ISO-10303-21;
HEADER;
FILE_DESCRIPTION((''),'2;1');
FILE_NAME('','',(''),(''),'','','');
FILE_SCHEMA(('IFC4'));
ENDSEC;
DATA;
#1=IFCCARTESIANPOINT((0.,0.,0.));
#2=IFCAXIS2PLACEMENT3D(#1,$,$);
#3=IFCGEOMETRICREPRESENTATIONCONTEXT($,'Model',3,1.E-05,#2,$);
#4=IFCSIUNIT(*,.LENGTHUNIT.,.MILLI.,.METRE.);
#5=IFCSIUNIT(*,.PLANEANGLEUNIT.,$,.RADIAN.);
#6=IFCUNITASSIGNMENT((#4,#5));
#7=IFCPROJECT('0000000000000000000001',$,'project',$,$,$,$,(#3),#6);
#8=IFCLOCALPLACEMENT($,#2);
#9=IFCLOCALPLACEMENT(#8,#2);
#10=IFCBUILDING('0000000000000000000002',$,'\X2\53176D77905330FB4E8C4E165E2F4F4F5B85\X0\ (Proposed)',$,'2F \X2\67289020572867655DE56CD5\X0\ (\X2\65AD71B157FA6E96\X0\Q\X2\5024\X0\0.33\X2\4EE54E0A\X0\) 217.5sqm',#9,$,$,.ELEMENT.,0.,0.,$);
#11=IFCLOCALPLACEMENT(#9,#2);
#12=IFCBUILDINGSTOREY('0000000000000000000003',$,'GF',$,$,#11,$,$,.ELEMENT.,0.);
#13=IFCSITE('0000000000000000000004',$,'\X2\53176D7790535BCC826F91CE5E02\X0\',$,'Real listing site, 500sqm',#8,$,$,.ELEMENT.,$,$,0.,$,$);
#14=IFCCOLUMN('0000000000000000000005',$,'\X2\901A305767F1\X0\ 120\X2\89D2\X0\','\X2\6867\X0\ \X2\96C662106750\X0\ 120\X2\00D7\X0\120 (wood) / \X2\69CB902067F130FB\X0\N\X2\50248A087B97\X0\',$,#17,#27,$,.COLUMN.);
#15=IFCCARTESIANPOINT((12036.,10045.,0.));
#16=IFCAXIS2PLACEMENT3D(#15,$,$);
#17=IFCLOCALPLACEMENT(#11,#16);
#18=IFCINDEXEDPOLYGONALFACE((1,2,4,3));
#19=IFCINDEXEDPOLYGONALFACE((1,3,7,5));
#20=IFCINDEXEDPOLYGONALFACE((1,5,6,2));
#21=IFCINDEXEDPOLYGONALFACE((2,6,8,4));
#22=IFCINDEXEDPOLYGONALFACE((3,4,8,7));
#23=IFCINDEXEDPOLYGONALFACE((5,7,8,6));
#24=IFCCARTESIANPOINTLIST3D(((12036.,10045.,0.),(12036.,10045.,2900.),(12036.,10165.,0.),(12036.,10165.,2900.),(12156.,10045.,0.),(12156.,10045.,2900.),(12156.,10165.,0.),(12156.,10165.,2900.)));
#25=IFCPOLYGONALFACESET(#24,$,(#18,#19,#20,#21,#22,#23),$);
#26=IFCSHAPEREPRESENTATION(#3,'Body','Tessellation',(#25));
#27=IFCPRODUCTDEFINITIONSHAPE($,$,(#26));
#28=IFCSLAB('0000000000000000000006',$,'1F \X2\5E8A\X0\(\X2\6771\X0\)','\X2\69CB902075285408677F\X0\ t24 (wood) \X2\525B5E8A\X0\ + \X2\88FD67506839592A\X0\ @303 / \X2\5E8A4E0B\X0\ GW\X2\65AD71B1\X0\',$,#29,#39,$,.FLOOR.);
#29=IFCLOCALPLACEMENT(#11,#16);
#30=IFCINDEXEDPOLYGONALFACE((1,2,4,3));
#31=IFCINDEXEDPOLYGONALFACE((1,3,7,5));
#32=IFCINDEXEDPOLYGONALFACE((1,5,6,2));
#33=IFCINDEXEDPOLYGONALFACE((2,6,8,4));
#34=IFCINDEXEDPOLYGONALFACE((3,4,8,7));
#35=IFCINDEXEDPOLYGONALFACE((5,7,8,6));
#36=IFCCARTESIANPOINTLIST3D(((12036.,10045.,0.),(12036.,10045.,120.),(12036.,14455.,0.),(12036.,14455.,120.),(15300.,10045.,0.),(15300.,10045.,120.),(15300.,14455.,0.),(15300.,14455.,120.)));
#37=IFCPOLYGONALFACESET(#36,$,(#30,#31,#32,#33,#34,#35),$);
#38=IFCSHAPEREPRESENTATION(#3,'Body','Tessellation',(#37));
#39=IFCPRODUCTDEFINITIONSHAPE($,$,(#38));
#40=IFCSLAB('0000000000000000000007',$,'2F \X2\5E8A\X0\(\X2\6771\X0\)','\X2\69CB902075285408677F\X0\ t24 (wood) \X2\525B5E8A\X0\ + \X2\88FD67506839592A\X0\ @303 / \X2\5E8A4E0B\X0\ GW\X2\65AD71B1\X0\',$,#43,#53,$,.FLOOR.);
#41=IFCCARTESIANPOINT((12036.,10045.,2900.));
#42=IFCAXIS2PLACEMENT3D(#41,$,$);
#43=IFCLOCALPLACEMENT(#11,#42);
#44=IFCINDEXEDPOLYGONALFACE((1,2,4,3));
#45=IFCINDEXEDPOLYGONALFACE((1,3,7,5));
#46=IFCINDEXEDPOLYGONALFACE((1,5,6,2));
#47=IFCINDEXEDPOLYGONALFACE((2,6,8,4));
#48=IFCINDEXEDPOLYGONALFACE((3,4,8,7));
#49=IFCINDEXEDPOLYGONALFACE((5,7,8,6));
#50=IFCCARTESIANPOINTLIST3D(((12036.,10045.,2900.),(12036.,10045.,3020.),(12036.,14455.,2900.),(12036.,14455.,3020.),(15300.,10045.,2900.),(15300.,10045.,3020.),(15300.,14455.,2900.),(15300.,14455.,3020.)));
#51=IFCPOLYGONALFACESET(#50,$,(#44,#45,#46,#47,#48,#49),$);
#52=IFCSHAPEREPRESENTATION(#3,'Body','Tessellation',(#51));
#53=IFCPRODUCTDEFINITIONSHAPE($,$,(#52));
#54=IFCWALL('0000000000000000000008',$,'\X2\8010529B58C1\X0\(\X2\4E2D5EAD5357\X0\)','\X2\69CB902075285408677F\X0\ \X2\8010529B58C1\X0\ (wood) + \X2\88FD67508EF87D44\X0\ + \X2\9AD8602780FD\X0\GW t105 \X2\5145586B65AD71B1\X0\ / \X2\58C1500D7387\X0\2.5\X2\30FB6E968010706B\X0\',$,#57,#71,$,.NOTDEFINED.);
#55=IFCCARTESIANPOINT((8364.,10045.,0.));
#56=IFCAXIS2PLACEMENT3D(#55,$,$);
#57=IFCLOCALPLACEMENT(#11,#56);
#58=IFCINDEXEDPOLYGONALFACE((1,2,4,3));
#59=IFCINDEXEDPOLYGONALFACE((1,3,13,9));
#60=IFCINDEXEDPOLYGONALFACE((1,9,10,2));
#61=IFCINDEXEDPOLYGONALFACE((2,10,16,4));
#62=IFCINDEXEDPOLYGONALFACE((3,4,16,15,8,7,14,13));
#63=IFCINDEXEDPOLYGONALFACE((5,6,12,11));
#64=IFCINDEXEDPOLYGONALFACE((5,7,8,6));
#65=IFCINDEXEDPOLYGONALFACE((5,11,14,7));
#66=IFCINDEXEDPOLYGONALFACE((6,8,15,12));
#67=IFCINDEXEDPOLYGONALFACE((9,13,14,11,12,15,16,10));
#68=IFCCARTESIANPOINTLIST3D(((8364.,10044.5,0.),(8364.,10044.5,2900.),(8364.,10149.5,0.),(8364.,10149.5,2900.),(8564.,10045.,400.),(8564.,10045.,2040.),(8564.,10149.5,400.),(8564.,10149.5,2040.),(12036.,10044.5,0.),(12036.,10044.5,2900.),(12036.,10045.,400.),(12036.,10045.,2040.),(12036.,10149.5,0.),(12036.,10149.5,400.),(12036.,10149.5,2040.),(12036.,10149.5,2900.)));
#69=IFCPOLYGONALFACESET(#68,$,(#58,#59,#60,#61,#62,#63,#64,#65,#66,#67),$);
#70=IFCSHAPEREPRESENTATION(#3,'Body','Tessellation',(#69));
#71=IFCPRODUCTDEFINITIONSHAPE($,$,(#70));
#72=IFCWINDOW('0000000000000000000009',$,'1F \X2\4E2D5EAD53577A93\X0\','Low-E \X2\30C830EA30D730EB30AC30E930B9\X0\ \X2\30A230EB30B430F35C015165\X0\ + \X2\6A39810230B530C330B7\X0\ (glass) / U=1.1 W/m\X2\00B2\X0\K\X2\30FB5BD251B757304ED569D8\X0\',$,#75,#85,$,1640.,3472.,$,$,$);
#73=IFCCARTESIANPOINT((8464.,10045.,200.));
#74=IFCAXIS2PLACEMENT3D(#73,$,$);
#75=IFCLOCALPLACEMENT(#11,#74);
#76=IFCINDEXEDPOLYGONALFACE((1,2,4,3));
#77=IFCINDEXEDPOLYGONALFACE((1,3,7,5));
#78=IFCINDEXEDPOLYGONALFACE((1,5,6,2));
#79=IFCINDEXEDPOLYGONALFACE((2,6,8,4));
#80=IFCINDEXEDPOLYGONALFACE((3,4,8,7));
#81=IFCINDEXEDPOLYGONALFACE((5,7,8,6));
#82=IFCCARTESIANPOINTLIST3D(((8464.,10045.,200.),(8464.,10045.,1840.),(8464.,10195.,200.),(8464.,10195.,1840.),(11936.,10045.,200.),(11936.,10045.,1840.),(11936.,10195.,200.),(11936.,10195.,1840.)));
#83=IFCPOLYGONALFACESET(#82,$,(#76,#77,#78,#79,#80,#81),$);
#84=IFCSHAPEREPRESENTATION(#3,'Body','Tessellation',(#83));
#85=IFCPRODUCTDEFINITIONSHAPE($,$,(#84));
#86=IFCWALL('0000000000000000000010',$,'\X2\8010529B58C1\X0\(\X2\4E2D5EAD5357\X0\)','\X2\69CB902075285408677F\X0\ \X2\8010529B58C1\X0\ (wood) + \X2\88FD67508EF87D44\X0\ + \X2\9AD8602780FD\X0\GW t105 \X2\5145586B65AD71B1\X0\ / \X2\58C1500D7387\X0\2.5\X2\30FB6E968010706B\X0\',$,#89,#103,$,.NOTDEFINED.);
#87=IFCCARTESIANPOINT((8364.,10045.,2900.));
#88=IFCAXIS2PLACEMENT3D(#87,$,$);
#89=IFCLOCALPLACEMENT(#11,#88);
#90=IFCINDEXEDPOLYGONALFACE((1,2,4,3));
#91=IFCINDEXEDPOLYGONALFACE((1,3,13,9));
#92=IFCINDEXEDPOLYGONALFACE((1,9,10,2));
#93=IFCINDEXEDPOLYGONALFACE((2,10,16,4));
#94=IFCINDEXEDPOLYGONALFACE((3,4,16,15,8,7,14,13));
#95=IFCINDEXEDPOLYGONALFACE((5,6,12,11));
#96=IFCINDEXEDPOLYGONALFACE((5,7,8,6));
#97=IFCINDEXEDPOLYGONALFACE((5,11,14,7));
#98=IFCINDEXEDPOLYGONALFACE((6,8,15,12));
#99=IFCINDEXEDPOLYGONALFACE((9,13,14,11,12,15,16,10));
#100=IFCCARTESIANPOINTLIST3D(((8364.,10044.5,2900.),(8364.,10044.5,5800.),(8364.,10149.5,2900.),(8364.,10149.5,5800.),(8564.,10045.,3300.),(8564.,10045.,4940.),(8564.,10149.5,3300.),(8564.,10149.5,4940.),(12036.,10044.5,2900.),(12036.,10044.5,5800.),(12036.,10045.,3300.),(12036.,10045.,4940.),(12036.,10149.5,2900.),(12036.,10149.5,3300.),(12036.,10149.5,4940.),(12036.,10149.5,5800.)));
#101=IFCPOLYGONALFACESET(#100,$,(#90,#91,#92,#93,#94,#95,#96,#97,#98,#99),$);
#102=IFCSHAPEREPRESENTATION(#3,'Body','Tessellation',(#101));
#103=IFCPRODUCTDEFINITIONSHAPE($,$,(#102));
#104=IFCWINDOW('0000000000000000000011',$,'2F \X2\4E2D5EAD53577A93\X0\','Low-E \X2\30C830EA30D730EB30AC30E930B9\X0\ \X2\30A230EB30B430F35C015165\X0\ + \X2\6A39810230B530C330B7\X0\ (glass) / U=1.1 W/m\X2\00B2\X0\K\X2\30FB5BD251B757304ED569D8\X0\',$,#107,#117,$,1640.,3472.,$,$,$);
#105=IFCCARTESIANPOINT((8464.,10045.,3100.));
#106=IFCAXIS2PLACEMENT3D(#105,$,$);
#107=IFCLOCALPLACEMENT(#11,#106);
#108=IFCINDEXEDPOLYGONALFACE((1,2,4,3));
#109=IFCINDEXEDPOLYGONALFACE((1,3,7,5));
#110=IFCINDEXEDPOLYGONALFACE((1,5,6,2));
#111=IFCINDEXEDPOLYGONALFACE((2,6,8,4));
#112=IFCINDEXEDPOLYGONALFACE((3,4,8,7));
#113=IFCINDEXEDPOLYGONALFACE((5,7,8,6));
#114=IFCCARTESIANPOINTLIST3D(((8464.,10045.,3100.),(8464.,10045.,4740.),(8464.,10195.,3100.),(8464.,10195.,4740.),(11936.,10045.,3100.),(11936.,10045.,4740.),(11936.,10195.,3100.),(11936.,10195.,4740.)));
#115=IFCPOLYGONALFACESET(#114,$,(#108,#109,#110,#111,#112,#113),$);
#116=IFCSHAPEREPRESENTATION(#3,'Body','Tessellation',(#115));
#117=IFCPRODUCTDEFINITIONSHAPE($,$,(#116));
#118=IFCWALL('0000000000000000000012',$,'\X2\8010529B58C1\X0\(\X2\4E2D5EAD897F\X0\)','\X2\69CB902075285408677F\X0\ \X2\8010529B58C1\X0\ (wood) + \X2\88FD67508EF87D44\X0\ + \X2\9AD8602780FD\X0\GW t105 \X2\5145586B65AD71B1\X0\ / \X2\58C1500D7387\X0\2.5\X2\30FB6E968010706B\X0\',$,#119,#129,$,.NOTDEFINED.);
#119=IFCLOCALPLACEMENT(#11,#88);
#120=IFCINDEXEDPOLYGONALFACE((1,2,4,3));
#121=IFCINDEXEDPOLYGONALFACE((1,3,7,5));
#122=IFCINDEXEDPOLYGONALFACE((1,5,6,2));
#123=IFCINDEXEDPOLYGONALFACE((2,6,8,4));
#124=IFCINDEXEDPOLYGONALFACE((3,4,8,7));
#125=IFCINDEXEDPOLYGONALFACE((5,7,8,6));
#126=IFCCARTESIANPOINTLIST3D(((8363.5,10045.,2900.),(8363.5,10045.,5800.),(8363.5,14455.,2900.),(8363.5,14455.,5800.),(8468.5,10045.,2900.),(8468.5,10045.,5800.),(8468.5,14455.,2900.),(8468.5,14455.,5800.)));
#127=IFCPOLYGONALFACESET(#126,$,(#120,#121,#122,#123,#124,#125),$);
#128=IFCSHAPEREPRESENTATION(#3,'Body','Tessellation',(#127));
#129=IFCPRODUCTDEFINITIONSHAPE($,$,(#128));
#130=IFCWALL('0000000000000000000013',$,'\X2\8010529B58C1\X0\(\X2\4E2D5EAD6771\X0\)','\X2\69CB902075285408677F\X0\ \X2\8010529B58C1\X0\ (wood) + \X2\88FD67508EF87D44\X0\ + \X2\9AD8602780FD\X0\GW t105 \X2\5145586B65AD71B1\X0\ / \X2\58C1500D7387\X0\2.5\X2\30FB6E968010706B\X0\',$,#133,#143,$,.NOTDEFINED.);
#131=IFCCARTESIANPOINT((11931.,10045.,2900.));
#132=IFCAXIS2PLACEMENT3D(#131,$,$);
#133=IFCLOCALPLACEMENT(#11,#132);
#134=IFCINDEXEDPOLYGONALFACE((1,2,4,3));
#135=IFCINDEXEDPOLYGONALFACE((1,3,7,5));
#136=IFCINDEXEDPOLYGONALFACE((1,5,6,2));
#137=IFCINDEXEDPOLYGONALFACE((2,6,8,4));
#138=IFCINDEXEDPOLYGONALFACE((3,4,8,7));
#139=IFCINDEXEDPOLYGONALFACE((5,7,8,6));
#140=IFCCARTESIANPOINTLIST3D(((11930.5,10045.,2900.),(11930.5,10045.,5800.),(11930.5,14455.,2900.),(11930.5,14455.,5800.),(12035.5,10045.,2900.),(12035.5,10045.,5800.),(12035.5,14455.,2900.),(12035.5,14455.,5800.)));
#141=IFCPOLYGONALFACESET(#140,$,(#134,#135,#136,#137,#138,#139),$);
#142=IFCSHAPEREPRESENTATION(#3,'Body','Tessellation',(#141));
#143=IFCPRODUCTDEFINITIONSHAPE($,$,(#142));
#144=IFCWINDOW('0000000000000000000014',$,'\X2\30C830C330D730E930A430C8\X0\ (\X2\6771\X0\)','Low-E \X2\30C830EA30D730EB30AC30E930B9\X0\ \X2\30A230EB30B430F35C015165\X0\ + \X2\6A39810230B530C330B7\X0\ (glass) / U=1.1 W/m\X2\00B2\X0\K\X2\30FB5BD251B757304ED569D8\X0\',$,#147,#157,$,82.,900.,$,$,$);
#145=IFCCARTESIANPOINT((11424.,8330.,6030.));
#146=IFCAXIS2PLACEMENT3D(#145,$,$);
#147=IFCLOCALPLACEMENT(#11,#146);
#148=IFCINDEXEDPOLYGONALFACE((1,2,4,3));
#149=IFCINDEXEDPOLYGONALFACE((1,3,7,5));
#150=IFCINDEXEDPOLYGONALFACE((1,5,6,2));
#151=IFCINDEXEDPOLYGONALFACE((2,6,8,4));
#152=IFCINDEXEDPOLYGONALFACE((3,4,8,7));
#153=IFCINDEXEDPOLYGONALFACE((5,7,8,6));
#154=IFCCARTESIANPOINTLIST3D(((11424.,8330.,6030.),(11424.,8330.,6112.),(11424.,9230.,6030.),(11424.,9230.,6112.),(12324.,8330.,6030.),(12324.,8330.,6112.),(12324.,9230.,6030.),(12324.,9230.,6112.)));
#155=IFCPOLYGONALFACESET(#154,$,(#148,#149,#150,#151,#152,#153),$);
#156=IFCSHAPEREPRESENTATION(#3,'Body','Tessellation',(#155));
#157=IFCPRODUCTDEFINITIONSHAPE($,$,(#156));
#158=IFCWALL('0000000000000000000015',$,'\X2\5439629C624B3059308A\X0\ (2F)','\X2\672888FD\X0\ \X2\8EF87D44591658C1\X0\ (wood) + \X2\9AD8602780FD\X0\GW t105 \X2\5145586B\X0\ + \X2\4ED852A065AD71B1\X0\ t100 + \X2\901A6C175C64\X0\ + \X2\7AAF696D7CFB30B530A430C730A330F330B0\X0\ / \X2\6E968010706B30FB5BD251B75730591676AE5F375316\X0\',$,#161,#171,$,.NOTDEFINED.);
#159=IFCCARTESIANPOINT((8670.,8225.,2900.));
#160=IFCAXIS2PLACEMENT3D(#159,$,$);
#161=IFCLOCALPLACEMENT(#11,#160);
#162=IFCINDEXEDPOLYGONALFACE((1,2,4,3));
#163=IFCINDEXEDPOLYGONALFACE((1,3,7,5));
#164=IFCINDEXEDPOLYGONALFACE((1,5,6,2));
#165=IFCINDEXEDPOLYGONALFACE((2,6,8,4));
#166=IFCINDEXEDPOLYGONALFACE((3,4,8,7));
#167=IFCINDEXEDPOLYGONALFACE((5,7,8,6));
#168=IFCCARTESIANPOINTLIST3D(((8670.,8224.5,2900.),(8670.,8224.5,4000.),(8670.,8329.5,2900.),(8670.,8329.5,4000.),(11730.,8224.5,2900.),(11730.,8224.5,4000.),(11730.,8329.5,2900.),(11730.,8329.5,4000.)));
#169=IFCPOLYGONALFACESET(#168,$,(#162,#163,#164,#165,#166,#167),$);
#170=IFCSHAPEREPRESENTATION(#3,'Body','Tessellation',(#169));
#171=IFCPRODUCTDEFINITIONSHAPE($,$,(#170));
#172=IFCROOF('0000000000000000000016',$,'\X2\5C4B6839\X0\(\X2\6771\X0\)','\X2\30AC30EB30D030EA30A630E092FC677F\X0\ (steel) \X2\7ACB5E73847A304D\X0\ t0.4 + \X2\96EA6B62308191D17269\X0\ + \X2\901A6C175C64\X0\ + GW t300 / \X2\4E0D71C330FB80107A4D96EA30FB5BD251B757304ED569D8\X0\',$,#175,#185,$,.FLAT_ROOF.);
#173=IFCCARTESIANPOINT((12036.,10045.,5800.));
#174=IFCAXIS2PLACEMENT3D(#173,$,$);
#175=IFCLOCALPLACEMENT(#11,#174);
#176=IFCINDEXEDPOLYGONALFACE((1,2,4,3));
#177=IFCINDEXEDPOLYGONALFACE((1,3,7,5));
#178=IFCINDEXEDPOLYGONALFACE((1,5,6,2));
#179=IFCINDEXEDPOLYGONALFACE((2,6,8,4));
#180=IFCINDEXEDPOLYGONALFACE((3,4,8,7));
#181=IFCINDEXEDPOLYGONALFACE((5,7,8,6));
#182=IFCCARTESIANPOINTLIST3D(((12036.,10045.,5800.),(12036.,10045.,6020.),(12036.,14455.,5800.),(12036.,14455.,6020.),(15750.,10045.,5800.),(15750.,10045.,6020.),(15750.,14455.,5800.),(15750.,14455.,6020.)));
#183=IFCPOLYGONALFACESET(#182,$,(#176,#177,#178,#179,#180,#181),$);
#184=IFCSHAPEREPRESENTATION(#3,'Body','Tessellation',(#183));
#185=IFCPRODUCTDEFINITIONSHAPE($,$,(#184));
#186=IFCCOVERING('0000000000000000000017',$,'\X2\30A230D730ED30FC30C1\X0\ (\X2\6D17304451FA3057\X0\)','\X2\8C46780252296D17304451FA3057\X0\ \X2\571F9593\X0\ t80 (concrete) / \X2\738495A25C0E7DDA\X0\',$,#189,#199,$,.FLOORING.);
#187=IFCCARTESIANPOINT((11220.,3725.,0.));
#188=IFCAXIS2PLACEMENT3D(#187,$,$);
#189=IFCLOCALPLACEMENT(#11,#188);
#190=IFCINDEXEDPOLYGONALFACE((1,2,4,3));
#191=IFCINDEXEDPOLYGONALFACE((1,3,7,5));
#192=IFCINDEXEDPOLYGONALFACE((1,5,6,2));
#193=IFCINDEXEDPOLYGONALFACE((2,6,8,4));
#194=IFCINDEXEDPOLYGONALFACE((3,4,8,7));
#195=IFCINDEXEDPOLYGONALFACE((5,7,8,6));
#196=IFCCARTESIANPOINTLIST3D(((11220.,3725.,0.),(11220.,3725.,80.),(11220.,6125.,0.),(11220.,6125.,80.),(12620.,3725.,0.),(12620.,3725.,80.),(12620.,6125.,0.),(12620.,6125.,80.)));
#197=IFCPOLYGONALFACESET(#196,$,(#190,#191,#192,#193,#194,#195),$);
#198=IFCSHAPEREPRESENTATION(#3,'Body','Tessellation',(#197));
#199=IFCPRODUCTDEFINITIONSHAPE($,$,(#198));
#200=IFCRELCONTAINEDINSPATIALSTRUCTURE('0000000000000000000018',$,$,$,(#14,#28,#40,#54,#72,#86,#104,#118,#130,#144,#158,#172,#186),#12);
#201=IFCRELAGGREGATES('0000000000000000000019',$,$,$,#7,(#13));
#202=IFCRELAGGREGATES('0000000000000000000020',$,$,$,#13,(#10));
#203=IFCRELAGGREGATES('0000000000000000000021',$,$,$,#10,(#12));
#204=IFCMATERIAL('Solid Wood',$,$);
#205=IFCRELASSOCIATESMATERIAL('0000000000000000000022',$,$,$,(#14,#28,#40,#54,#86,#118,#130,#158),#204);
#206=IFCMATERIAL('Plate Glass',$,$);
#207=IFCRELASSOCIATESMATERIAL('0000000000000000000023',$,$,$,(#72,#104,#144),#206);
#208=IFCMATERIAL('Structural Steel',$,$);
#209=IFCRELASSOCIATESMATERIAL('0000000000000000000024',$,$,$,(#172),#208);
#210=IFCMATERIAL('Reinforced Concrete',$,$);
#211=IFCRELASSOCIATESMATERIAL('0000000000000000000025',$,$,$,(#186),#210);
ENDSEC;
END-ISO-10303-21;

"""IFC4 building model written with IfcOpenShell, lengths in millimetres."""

from ifc_helpers import new_model, si_unit, frame, frame_2d, origin, place, context, project, spatial, rectangle, extrude, material, element, fill, save


model = new_model("IFC4")

# Units and contexts
model_context = context("Model", 3, precision=1e-05, world=origin())
ifc_project = project(units=[si_unit("LENGTHUNIT", "METRE", prefix="MILLI"), si_unit("PLANEANGLEUNIT", "RADIAN")], contexts=[model_context])

# Site, building, storey
site_placement = place(None, origin())
site = spatial("IfcSite", under=ifc_project, at=site_placement, Name="北海道富良野市", ObjectType="Real listing site, 500sqm", CompositionType="ELEMENT", RefElevation=0.0)
building_placement = place(site_placement, origin())
building = spatial("IfcBuilding", under=site, at=building_placement, Name="北海道・二世帯住宅 (Proposed)", ObjectType="2F 木造在来工法 (断熱基準Q値0.33以上) 217.5sqm", CompositionType="ELEMENT", ElevationOfRefHeight=0.0, ElevationOfTerrain=0.0)
storey_placement = place(building_placement, origin())
storey = spatial("IfcBuildingStorey", under=building, at=storey_placement, Name="GF", CompositionType="ELEMENT", Elevation=0.0)

# Column
ifc_material_1 = material(Name="Solid Wood")
column_1_placement = place(storey_placement, frame((12036.0, 10045.0, 0.0)))
element("IfcColumn", 1, at=column_1_placement, inside=storey, material=ifc_material_1, Name="通し柱 120角", Description="桧 集成材 120×120 (wood) / 構造柱・N値計算", PredefinedType="COLUMN", context=model_context, shape_type="SweptSolid", body=[
    extrude(rectangle(XDim=120.0, YDim=120.0, at=frame_2d((60.0, 60.0))), frame((12036.0, 10045.0, 0.0)), (0.0, 0.0, 1.0), 2900.0),
])

# Slabs
slab_1_placement = place(storey_placement, frame((12036.0, 10045.0, 0.0)))
element("IfcSlab", 2, at=slab_1_placement, inside=storey, material=ifc_material_1, Name="1F 床(東)", Description="構造用合板 t24 (wood) 剛床 + 製材根太 @303 / 床下 GW断熱", PredefinedType="FLOOR", context=model_context, shape_type="SweptSolid", body=[
    extrude(rectangle(XDim=3264.0, YDim=4410.0, at=frame_2d((1632.0, 2205.0))), frame((12036.0, 10045.0, 0.0)), (0.0, 0.0, 1.0), 120.0),
])
slab_2_placement = place(storey_placement, frame((12036.0, 10045.0, 2900.0)))
element("IfcSlab", 3, at=slab_2_placement, inside=storey, material=ifc_material_1, Name="2F 床(東)", Description="構造用合板 t24 (wood) 剛床 + 製材根太 @303 / 床下 GW断熱", PredefinedType="FLOOR", context=model_context, shape_type="SweptSolid", body=[
    extrude(rectangle(XDim=3264.0, YDim=4410.0, at=frame_2d((1632.0, 2205.0))), frame((12036.0, 10045.0, 2900.0)), (0.0, 0.0, 1.0), 120.0),
])

# Wall, opening, window
wall_1_placement = place(storey_placement, frame((8364.0, 10045.0, 0.0)))
wall_1 = element("IfcWall", 4, at=wall_1_placement, inside=storey, material=ifc_material_1, Name="耐力壁(中庭南)", Description="構造用合板 耐力壁 (wood) + 製材軸組 + 高性能GW t105 充填断熱 / 壁倍率2.5・準耐火", PredefinedType="NOTDEFINED", context=model_context, shape_type="SweptSolid", body=[
    extrude(rectangle(XDim=3672.0, YDim=105.0, at=frame_2d((1836.0, 52.0))), frame((8364.0, 10045.0, 0.0)), (0.0, 0.0, 1.0), 2900.0),
])
opening_1_placement = place(storey_placement, frame((8464.0, 10045.0, 200.0)))
opening_1 = element("IfcOpeningElement", 5, at=opening_1_placement, cuts=wall_1, PredefinedType="NOTDEFINED", context=model_context, shape_type="SweptSolid", body=[
    extrude(rectangle(XDim=3472.0, YDim=150.0, at=frame_2d((1736.0, 75.0))), frame((8464.0, 10045.0, 200.0)), (0.0, 0.0, 1.0), 1640.0),
])
ifc_material_2 = material(Name="Plate Glass")
window_1_placement = place(storey_placement, frame((8464.0, 10045.0, 200.0)))
window_1 = element("IfcWindow", 6, at=window_1_placement, inside=storey, material=ifc_material_2, Name="1F 中庭南窓", Description="Low-E トリプルガラス アルゴン封入 + 樹脂サッシ (glass) / U=1.1 W/m²K・寒冷地仕様", OverallHeight=1640.0, OverallWidth=3472.0, context=model_context, shape_type="SweptSolid", body=[
    extrude(rectangle(XDim=3472.0, YDim=150.0, at=frame_2d((1736.0, 75.0))), frame((8464.0, 10045.0, 200.0)), (0.0, 0.0, 1.0), 1640.0),
])
fill(opening_1, window_1)

# Wall, opening, window
wall_2_placement = place(storey_placement, frame((8364.0, 10045.0, 2900.0)))
wall_2 = element("IfcWall", 7, at=wall_2_placement, inside=storey, material=ifc_material_1, Name="耐力壁(中庭南)", Description="構造用合板 耐力壁 (wood) + 製材軸組 + 高性能GW t105 充填断熱 / 壁倍率2.5・準耐火", PredefinedType="NOTDEFINED", context=model_context, shape_type="SweptSolid", body=[
    extrude(rectangle(XDim=3672.0, YDim=105.0, at=frame_2d((1836.0, 52.0))), frame((8364.0, 10045.0, 2900.0)), (0.0, 0.0, 1.0), 2900.0),
])
opening_2_placement = place(storey_placement, frame((8464.0, 10045.0, 3100.0)))
opening_2 = element("IfcOpeningElement", 8, at=opening_2_placement, cuts=wall_2, PredefinedType="NOTDEFINED", context=model_context, shape_type="SweptSolid", body=[
    extrude(rectangle(XDim=3472.0, YDim=150.0, at=frame_2d((1736.0, 75.0))), frame((8464.0, 10045.0, 3100.0)), (0.0, 0.0, 1.0), 1640.0),
])
window_2_placement = place(storey_placement, frame((8464.0, 10045.0, 3100.0)))
window_2 = element("IfcWindow", 9, at=window_2_placement, inside=storey, material=ifc_material_2, Name="2F 中庭南窓", Description="Low-E トリプルガラス アルゴン封入 + 樹脂サッシ (glass) / U=1.1 W/m²K・寒冷地仕様", OverallHeight=1640.0, OverallWidth=3472.0, context=model_context, shape_type="SweptSolid", body=[
    extrude(rectangle(XDim=3472.0, YDim=150.0, at=frame_2d((1736.0, 75.0))), frame((8464.0, 10045.0, 3100.0)), (0.0, 0.0, 1.0), 1640.0),
])
fill(opening_2, window_2)

# Walls
wall_3_placement = place(storey_placement, frame((8364.0, 10045.0, 2900.0)))
element("IfcWall", 10, at=wall_3_placement, inside=storey, material=ifc_material_1, Name="耐力壁(中庭西)", Description="構造用合板 耐力壁 (wood) + 製材軸組 + 高性能GW t105 充填断熱 / 壁倍率2.5・準耐火", PredefinedType="NOTDEFINED", context=model_context, shape_type="SweptSolid", body=[
    extrude(rectangle(XDim=105.0, YDim=4410.0, at=frame_2d((52.0, 2205.0))), frame((8364.0, 10045.0, 2900.0)), (0.0, 0.0, 1.0), 2900.0),
])
wall_4_placement = place(storey_placement, frame((11931.0, 10045.0, 2900.0)))
element("IfcWall", 11, at=wall_4_placement, inside=storey, material=ifc_material_1, Name="耐力壁(中庭東)", Description="構造用合板 耐力壁 (wood) + 製材軸組 + 高性能GW t105 充填断熱 / 壁倍率2.5・準耐火", PredefinedType="NOTDEFINED", context=model_context, shape_type="SweptSolid", body=[
    extrude(rectangle(XDim=105.0, YDim=4410.0, at=frame_2d((52.0, 2205.0))), frame((11931.0, 10045.0, 2900.0)), (0.0, 0.0, 1.0), 2900.0),
])

# Window
window_3_placement = place(storey_placement, frame((11424.0, 8330.0, 6030.0)))
element("IfcWindow", 12, at=window_3_placement, inside=storey, material=ifc_material_2, Name="トップライト (東)", Description="Low-E トリプルガラス アルゴン封入 + 樹脂サッシ (glass) / U=1.1 W/m²K・寒冷地仕様", OverallHeight=82.0, OverallWidth=900.0, context=model_context, shape_type="SweptSolid", body=[
    extrude(rectangle(XDim=900.0, YDim=900.0, at=frame_2d((450.0, 450.0))), frame((11424.0, 8330.0, 6030.0)), (0.0, 0.0, 1.0), 82.0),
])

# Wall
wall_5_placement = place(storey_placement, frame((8670.0, 8225.0, 2900.0)))
element("IfcWall", 13, at=wall_5_placement, inside=storey, material=ifc_material_1, Name="吹抜手すり (2F)", Description="木製 軸組外壁 (wood) + 高性能GW t105 充填 + 付加断熱 t100 + 通気層 + 窯業系サイディング / 準耐火・寒冷地外皮強化", PredefinedType="NOTDEFINED", context=model_context, shape_type="SweptSolid", body=[
    extrude(rectangle(XDim=3060.0, YDim=105.0, at=frame_2d((1530.0, 52.0))), frame((8670.0, 8225.0, 2900.0)), (0.0, 0.0, 1.0), 1100.0),
])

# Roof
ifc_material_3 = material(Name="Structural Steel")
for number, where, name in (
    (14, (12036.0, 10045.0, 5800.0), "屋根(東)"),
):
    element("IfcRoof", number, at=place(storey_placement, frame(where)), inside=storey, material=ifc_material_3, Name=name, Description="ガルバリウム鋼板 (steel) 立平葺き t0.4 + 雪止め金物 + 通気層 + GW t300 / 不燃・耐積雪・寒冷地仕様", PredefinedType="FLAT_ROOF", context=model_context, shape_type="SweptSolid", body=[
        extrude(rectangle(XDim=3714.0, YDim=4410.0, at=frame_2d((1857.0, 2205.0))), frame((12036.0, 10045.0, 5800.0)), (0.0, 0.0, 1.0), 220.0),
    ])

# Covering
ifc_material_4 = material(Name="Reinforced Concrete")
covering_placement = place(storey_placement, frame((11220.0, 3725.0, 0.0)))
element("IfcCovering", 15, at=covering_placement, inside=storey, material=ifc_material_4, Name="アプローチ (洗い出し)", Description="豆砂利洗い出し 土間 t80 (concrete) / 玄関導線", PredefinedType="FLOORING", context=model_context, shape_type="SweptSolid", body=[
    extrude(rectangle(XDim=1400.0, YDim=2400.0, at=frame_2d((700.0, 1200.0))), frame((11220.0, 3725.0, 0.0)), (0.0, 0.0, 1.0), 80.0),
])

save(model, "model.ifc")
